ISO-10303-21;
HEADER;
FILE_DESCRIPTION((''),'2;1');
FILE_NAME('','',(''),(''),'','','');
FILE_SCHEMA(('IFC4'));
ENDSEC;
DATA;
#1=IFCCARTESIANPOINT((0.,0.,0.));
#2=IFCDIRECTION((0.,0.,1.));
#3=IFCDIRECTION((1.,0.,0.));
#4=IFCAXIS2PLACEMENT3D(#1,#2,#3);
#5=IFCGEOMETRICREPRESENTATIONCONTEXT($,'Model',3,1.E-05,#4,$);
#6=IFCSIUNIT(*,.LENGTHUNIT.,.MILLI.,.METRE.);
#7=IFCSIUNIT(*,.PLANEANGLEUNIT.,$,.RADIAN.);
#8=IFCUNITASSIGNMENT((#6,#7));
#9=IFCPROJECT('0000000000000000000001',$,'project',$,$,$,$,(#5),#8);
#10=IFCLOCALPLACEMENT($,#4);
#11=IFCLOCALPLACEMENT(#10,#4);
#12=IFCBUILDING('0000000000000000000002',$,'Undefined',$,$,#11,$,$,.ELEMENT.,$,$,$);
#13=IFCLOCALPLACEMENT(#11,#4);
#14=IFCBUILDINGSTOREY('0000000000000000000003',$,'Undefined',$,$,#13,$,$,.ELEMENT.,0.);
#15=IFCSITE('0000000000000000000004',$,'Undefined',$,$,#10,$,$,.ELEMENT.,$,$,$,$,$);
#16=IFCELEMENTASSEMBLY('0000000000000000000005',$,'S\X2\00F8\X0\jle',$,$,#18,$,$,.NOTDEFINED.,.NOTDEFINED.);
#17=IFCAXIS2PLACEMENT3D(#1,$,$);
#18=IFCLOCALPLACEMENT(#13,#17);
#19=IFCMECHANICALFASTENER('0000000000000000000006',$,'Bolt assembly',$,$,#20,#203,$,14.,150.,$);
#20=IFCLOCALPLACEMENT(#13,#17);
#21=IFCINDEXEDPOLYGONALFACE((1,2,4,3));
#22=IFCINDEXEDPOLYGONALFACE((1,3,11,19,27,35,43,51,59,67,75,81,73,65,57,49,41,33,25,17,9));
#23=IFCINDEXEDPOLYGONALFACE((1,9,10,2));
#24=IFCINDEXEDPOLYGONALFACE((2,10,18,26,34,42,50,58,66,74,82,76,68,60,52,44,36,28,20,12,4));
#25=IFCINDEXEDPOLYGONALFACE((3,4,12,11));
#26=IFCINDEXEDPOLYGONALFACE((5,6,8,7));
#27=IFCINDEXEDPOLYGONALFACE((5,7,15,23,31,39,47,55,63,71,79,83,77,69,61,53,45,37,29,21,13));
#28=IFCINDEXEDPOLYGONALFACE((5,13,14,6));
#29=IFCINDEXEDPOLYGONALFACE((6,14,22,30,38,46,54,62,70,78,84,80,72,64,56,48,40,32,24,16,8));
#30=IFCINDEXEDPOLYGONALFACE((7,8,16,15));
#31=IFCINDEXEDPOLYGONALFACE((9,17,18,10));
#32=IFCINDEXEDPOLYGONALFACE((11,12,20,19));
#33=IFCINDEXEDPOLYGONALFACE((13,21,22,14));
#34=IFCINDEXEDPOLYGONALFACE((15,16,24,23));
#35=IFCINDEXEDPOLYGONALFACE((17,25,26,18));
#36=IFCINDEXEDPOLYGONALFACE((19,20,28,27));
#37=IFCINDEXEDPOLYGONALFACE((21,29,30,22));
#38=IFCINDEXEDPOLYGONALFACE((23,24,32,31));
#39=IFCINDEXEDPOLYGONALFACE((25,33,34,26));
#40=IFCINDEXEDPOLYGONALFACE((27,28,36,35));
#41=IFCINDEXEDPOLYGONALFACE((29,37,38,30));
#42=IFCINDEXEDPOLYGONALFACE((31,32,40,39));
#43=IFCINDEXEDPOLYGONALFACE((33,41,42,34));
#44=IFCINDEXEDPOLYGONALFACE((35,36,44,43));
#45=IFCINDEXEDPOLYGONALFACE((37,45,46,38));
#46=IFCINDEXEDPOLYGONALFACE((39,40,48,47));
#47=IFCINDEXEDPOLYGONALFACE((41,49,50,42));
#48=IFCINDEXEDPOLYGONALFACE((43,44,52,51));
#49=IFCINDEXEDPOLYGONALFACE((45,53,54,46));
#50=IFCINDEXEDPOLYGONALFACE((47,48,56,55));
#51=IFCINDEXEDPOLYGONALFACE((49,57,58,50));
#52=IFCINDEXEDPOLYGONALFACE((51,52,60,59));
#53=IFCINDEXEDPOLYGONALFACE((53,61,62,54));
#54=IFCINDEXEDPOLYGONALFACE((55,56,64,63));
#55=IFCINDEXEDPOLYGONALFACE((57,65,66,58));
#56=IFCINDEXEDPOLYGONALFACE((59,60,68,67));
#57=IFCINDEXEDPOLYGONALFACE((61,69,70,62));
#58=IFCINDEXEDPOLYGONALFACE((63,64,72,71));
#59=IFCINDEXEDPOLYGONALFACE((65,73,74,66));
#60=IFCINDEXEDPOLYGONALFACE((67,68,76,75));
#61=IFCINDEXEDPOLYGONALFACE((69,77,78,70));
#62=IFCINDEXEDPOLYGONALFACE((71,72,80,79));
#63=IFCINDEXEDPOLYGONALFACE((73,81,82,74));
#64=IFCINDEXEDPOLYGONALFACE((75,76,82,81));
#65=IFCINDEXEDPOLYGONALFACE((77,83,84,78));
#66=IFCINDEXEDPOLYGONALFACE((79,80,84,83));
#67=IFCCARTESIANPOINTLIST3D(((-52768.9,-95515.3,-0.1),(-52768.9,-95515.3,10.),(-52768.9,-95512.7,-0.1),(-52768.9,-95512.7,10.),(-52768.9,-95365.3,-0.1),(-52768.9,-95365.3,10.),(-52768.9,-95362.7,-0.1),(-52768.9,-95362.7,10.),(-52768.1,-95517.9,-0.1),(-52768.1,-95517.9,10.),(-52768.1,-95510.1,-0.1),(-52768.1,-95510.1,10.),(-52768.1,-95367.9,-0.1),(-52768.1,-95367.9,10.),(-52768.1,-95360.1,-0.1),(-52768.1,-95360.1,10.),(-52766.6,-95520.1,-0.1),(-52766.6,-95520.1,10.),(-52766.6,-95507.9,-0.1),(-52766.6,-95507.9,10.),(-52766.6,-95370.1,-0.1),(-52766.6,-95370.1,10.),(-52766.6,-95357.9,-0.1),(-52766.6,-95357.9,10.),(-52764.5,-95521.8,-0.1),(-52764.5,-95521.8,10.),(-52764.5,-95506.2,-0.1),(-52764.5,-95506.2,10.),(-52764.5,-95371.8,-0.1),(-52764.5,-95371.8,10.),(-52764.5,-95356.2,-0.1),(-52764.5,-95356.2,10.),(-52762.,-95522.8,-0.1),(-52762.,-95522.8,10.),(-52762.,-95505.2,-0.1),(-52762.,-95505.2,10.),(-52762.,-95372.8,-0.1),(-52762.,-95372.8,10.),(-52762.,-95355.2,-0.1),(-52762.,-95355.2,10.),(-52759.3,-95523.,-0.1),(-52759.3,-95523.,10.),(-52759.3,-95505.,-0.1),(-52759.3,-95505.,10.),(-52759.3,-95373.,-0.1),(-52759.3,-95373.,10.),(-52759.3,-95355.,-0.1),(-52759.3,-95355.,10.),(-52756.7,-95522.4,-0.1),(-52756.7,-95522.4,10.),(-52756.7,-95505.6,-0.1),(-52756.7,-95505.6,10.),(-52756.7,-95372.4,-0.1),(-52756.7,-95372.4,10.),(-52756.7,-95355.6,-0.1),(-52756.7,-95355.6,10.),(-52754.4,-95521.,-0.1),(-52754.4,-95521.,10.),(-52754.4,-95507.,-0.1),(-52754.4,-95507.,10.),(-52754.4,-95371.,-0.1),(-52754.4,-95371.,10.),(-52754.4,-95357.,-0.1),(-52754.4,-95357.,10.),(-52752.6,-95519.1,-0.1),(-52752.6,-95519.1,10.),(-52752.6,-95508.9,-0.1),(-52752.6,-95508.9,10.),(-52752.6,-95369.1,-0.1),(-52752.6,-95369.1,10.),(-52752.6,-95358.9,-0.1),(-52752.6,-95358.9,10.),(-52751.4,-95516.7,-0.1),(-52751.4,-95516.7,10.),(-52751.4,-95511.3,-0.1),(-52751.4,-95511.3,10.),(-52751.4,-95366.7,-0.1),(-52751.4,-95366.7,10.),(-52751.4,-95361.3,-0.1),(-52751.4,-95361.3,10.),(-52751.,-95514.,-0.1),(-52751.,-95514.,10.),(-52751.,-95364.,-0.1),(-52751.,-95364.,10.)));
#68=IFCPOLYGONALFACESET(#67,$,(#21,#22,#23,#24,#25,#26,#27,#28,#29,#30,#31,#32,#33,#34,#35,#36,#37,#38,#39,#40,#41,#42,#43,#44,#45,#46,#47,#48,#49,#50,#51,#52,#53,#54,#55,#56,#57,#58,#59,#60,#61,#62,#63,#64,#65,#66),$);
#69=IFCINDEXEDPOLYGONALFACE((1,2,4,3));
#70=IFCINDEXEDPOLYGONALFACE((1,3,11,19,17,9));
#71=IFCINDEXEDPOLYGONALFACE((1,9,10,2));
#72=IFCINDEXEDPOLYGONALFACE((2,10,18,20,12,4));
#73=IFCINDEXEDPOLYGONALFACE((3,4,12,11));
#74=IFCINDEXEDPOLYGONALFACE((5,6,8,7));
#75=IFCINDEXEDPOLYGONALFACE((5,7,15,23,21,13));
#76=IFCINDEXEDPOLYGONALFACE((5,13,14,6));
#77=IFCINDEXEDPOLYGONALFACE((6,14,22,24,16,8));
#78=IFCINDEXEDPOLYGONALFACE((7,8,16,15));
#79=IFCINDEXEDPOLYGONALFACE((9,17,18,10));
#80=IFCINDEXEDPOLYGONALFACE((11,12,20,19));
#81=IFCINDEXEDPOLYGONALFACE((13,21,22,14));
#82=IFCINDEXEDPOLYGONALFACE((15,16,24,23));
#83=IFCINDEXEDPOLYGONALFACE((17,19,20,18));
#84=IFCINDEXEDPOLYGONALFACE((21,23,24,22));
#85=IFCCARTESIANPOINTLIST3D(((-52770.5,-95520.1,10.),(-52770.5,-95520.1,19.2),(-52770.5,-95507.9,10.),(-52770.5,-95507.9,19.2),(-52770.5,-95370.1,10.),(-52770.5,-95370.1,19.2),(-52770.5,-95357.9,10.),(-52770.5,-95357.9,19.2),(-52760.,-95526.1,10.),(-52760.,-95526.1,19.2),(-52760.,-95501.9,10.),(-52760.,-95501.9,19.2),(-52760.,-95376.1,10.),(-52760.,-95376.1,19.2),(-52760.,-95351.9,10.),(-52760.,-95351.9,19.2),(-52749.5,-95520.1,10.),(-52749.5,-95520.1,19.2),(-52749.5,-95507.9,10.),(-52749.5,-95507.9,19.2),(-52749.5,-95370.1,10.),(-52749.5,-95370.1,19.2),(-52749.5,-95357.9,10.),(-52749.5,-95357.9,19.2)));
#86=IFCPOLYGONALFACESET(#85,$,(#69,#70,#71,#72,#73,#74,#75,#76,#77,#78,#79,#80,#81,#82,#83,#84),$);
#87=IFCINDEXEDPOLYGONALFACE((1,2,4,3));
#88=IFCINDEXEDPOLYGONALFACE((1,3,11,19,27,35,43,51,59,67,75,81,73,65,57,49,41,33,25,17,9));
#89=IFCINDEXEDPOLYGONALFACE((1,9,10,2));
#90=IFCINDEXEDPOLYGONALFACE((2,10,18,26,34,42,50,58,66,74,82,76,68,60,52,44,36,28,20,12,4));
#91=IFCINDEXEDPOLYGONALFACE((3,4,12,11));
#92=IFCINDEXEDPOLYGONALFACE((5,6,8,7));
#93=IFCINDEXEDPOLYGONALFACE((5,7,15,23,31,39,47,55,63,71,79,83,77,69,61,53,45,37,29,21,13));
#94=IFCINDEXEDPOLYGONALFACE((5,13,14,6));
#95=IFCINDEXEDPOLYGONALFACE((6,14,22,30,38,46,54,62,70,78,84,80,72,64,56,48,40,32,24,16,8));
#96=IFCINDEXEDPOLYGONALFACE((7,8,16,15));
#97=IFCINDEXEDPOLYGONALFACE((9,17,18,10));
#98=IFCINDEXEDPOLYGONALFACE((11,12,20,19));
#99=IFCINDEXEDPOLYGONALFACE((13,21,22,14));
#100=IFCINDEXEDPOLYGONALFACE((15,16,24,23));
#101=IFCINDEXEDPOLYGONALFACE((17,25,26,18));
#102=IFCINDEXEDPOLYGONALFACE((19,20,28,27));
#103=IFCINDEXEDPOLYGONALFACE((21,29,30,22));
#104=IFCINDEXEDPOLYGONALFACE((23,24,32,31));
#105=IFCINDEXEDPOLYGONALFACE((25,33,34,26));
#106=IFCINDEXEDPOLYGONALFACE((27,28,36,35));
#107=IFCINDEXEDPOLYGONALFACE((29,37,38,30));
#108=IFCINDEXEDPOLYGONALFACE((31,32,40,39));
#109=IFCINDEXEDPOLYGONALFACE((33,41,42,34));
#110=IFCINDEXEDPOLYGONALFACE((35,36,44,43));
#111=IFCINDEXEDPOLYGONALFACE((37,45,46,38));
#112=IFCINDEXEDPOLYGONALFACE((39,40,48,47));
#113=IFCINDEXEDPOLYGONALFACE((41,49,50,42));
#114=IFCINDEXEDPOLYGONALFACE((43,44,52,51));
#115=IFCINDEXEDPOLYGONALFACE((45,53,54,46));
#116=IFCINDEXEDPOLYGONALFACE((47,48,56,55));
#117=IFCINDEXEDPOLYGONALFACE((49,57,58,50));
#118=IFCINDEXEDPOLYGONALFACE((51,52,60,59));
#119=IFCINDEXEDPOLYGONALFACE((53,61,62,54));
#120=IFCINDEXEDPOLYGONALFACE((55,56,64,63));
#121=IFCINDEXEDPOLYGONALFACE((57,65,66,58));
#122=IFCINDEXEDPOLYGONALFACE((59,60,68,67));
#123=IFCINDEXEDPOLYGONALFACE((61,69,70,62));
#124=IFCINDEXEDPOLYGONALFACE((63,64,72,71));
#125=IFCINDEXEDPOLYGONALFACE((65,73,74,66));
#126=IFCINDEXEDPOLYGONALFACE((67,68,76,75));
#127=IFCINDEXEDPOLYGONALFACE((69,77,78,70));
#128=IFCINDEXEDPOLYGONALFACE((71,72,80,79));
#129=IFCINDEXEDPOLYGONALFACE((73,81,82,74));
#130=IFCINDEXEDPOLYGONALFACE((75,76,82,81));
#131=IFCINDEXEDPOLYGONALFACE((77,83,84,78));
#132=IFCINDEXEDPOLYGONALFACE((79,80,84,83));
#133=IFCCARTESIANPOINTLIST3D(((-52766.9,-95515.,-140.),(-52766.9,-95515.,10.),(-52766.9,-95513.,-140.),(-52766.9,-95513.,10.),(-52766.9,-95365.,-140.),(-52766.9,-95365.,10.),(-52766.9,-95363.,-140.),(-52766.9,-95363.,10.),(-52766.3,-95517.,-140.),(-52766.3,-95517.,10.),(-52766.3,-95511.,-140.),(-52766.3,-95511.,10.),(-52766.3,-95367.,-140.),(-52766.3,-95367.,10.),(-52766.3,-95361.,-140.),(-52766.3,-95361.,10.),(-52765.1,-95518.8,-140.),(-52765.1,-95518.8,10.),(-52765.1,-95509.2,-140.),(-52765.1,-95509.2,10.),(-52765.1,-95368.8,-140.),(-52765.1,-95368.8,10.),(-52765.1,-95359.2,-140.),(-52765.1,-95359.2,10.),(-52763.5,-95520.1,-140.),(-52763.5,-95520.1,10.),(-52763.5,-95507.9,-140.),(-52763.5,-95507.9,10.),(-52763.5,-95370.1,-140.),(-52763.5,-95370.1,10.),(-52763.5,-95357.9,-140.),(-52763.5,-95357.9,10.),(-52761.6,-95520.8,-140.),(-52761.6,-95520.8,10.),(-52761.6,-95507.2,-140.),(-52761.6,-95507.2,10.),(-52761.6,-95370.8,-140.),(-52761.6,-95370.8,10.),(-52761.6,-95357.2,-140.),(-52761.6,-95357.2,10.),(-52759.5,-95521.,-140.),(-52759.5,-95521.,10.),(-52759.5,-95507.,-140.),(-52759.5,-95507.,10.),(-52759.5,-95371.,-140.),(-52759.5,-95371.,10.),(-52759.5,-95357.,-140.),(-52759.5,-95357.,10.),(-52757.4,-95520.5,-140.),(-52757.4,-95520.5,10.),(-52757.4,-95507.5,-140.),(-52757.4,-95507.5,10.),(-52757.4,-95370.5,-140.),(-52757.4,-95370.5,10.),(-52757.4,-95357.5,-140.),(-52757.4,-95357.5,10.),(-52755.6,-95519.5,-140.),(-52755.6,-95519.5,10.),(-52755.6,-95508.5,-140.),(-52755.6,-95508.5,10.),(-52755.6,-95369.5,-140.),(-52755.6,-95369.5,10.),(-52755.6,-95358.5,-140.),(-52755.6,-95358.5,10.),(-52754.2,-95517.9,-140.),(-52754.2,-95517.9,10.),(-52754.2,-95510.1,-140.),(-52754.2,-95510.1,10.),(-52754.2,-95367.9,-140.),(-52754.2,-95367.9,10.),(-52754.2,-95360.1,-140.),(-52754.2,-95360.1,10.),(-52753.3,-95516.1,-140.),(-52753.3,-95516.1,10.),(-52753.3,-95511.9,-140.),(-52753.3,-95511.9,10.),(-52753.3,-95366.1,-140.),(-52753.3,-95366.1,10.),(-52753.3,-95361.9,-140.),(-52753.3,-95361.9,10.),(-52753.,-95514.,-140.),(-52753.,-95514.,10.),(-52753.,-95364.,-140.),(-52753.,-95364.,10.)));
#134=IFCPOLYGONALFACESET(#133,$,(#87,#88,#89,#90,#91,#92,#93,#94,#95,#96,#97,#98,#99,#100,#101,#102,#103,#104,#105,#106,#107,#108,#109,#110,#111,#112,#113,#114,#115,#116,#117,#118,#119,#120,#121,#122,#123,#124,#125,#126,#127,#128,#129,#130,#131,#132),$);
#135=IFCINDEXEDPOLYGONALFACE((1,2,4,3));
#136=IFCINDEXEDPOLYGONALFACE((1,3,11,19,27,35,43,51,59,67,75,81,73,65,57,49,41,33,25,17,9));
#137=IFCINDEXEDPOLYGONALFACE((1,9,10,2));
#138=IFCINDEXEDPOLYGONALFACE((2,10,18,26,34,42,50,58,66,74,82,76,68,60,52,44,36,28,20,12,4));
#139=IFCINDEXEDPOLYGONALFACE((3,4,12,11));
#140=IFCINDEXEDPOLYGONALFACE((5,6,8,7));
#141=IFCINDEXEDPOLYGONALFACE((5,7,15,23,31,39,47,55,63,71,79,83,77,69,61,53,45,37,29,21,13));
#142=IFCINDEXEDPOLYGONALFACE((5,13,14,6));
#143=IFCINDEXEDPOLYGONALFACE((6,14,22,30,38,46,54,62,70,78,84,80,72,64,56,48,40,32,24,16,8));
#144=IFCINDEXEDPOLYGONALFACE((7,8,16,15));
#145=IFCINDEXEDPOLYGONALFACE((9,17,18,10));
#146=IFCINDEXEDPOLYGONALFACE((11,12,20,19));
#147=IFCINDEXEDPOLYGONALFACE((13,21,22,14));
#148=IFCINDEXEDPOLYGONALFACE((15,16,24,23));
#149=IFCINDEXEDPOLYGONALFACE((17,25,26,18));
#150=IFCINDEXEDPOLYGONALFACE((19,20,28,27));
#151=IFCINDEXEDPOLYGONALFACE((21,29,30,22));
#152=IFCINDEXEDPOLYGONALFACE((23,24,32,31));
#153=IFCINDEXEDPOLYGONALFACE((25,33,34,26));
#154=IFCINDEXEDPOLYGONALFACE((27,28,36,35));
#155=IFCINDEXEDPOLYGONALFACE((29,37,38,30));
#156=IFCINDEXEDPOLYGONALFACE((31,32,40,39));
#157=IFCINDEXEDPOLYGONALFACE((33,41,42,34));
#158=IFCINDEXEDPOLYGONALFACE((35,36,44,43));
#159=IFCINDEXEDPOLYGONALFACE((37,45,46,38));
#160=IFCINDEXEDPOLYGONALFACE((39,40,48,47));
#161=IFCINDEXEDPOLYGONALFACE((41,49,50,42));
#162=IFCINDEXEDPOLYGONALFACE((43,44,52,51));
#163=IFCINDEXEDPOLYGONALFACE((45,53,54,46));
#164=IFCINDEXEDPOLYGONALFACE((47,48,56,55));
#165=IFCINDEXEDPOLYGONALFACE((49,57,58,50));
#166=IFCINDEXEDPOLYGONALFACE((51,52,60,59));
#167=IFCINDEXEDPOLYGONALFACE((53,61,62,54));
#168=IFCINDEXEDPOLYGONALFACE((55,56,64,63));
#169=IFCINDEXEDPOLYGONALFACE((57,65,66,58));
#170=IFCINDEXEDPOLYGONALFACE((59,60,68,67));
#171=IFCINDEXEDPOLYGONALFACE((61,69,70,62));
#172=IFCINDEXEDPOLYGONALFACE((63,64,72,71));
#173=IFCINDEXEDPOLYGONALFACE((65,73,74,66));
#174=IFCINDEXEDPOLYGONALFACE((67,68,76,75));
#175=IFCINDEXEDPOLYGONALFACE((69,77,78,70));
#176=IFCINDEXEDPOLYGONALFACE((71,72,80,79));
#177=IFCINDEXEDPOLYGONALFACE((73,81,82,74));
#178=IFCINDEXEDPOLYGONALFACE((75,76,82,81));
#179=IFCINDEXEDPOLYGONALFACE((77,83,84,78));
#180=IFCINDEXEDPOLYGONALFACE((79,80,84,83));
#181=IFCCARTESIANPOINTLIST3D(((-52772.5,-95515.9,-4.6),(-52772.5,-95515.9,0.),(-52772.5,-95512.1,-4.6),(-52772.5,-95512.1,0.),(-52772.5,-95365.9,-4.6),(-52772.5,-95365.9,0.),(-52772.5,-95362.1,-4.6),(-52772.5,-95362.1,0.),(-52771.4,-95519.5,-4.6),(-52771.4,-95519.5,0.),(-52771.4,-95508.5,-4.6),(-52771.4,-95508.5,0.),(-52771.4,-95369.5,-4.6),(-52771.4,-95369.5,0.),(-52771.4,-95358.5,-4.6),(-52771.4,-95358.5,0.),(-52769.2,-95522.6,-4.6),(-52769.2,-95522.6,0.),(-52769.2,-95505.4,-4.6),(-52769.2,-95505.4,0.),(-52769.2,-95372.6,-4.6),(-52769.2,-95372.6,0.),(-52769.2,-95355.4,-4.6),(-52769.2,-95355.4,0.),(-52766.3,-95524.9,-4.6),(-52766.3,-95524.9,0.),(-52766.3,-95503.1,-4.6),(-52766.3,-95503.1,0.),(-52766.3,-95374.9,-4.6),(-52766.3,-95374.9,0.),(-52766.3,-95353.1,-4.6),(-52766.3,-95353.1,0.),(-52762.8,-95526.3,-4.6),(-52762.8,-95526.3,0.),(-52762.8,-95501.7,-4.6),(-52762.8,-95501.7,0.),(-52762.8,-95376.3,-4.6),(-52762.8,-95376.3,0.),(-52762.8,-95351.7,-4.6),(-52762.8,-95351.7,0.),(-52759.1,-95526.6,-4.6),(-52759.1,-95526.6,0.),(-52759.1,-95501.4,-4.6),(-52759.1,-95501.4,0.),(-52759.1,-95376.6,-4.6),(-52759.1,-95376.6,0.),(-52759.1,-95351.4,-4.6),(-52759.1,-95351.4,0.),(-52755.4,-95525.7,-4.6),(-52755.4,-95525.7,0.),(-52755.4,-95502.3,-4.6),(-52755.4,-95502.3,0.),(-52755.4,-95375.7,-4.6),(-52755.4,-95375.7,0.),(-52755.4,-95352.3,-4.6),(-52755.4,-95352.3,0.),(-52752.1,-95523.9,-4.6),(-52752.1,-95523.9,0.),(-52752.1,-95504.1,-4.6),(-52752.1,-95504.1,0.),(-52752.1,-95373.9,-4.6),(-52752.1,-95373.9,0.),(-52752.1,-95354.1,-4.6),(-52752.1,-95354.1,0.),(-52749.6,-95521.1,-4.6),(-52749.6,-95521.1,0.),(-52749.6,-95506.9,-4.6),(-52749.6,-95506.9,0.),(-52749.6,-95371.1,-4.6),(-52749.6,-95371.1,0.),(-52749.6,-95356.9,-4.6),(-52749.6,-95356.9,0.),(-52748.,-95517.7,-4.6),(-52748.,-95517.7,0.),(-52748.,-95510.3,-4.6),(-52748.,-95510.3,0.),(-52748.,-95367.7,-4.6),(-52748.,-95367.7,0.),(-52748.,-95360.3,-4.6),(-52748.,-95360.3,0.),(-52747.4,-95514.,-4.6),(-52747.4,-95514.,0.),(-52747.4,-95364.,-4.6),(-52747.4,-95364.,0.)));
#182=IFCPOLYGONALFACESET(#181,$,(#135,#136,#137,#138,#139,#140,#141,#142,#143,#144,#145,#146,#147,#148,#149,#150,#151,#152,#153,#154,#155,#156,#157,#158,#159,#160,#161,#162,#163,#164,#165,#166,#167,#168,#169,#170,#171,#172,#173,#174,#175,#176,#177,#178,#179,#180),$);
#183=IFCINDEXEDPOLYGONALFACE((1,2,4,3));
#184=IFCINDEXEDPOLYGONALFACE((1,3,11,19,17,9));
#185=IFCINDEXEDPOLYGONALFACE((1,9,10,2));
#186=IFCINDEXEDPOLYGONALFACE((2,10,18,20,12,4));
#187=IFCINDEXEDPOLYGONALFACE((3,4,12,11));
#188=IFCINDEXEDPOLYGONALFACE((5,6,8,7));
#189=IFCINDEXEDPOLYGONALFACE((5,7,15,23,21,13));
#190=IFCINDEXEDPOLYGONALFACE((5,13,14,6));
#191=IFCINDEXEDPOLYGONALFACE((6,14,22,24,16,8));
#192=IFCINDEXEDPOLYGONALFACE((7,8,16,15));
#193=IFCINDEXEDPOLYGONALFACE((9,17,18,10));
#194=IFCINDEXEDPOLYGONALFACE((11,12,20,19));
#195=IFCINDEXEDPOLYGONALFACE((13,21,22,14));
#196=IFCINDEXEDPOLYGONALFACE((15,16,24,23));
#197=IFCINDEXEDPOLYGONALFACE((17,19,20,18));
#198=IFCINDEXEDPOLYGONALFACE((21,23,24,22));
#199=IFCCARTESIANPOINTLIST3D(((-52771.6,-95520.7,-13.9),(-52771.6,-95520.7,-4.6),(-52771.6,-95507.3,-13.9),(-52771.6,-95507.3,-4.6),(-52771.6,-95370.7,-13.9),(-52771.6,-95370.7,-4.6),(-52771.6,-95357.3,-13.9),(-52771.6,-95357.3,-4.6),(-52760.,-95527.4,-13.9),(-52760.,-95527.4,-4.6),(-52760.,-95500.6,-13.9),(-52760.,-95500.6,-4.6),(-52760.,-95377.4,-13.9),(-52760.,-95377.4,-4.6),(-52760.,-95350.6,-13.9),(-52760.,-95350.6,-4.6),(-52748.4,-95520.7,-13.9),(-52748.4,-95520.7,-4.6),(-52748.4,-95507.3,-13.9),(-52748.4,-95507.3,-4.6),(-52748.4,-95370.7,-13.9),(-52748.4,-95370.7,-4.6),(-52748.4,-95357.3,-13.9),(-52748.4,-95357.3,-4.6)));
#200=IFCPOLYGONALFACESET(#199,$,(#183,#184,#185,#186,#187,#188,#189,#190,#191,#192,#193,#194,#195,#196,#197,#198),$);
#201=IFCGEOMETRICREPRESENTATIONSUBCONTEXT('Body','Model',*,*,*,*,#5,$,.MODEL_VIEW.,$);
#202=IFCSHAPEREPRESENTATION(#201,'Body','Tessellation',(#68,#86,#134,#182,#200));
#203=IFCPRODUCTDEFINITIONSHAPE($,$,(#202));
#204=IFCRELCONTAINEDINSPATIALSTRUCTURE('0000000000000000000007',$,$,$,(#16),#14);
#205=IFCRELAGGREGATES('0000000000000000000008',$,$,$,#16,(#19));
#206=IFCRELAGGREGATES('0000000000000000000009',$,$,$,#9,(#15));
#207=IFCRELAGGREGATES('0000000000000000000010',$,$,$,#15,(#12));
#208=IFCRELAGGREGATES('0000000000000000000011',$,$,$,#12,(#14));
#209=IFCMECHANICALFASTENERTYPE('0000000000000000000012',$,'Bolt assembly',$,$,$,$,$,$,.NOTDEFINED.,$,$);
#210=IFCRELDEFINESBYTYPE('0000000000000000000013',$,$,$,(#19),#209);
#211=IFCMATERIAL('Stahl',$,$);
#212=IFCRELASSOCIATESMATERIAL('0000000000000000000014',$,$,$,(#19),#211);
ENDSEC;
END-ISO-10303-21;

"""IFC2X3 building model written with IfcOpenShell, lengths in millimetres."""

from ifc_helpers import new_model, si_unit, frame, origin_with_axes, origin_2d_with_axis, place, context, subcontext, project, spatial, polyline, circle, outline, extrude, source, transform, mapped, material, type_object, element, aggregate, save


model = new_model("IFC2X3")

# Units and contexts
model_context = context("Model", 3, precision=1e-05, world=origin_with_axes())
body_context = subcontext(model_context, "Body", "Model", "MODEL_VIEW")
ifc_project = project(units=[si_unit("LENGTHUNIT", "METRE", prefix="MILLI"), si_unit("PLANEANGLEUNIT", "RADIAN")], contexts=[model_context])

# Site, building, storey
site_placement = place(None, origin_with_axes())
site = spatial("IfcSite", under=ifc_project, at=site_placement, Name="Undefined", CompositionType="ELEMENT")
building_placement = place(site_placement, origin_with_axes())
building = spatial("IfcBuilding", under=site, at=building_placement, Name="Undefined", CompositionType="ELEMENT")
storey_placement = place(building_placement, origin_with_axes())
storey = spatial("IfcBuildingStorey", under=building, at=storey_placement, Name="Undefined", CompositionType="ELEMENT", Elevation=0.0)

# Element assembly
assembly_1_placement = place(storey_placement, origin_with_axes())
assembly_1 = element("IfcElementAssembly", 1, at=assembly_1_placement, inside=storey, Name="Søjle", AssemblyPlace="NOTDEFINED", PredefinedType="NOTDEFINED")

# Shared definitions
mechanical_fastener_type = type_object("IfcMechanicalFastenerType", Name="Bolt assembly")

# Mechanical fastener
ifc_material_1 = material(Name="Stahl")
shared_shape_1 = source(origin_with_axes(), body_context, "Body", "SweptSolid", [
    extrude(circle(Radius=9.0, at=origin_2d_with_axis()), frame((0.0, 0.0, 0.0), z_axis=(0.0, 1.0, 0.0), x_axis=(1.0, 0.0, 0.0)), (0.0, 0.0, 1.0), 10.1),
    extrude(outline(polyline([(10.5, -6.1), (10.5, 6.1), (0.0, 12.1), (-10.5, 6.1), (-10.5, -6.1), (0.0, -12.1), (10.5, -6.1)])), frame((0.0, -9.2, 0.0), z_axis=(0.0, 1.0, 0.0), x_axis=(1.0, 0.0, 0.0)), (0.0, 0.0, 1.0), 9.2),
    extrude(circle(Radius=7.0, at=origin_2d_with_axis()), frame((0.0, 0.0, 0.0), z_axis=(0.0, 1.0, 0.0), x_axis=(1.0, 0.0, 0.0)), (0.0, 0.0, 1.0), 150.0),
    extrude(circle(Radius=12.6, at=origin_2d_with_axis()), frame((0.0, 10.0, 0.0), z_axis=(0.0, 1.0, 0.0), x_axis=(1.0, 0.0, 0.0)), (0.0, 0.0, 1.0), 4.6),
    extrude(outline(polyline([(11.6, -6.7), (11.6, 6.7), (0.0, 13.4), (-11.6, 6.7), (-11.6, -6.7), (0.0, -13.4), (11.6, -6.7)])), frame((0.0, 14.6, 0.0), z_axis=(0.0, 1.0, 0.0), x_axis=(1.0, 0.0, 0.0)), (0.0, 0.0, 1.0), 9.2),
])
mechanical_fastener_1_placement = place(assembly_1_placement, frame((-52760.0, -95439.0, 10.0), z_axis=(0.0, 1.0, 0.0), x_axis=(1.0, 0.0, 0.0)))
mechanical_fastener_1 = element("IfcMechanicalFastener", 2, at=mechanical_fastener_1_placement, type_object=mechanical_fastener_type, material=ifc_material_1, Name="Bolt assembly", NominalDiameter=14.0, NominalLength=150.0, context=body_context, shape_type="MappedRepresentation", body=[
    mapped(shared_shape_1, transform((0.0, 0.0, -75.0))),
    mapped(shared_shape_1, transform((0.0, 0.0, 75.0))),
])
aggregate(assembly_1, [mechanical_fastener_1])

save(model, "model.ifc")
